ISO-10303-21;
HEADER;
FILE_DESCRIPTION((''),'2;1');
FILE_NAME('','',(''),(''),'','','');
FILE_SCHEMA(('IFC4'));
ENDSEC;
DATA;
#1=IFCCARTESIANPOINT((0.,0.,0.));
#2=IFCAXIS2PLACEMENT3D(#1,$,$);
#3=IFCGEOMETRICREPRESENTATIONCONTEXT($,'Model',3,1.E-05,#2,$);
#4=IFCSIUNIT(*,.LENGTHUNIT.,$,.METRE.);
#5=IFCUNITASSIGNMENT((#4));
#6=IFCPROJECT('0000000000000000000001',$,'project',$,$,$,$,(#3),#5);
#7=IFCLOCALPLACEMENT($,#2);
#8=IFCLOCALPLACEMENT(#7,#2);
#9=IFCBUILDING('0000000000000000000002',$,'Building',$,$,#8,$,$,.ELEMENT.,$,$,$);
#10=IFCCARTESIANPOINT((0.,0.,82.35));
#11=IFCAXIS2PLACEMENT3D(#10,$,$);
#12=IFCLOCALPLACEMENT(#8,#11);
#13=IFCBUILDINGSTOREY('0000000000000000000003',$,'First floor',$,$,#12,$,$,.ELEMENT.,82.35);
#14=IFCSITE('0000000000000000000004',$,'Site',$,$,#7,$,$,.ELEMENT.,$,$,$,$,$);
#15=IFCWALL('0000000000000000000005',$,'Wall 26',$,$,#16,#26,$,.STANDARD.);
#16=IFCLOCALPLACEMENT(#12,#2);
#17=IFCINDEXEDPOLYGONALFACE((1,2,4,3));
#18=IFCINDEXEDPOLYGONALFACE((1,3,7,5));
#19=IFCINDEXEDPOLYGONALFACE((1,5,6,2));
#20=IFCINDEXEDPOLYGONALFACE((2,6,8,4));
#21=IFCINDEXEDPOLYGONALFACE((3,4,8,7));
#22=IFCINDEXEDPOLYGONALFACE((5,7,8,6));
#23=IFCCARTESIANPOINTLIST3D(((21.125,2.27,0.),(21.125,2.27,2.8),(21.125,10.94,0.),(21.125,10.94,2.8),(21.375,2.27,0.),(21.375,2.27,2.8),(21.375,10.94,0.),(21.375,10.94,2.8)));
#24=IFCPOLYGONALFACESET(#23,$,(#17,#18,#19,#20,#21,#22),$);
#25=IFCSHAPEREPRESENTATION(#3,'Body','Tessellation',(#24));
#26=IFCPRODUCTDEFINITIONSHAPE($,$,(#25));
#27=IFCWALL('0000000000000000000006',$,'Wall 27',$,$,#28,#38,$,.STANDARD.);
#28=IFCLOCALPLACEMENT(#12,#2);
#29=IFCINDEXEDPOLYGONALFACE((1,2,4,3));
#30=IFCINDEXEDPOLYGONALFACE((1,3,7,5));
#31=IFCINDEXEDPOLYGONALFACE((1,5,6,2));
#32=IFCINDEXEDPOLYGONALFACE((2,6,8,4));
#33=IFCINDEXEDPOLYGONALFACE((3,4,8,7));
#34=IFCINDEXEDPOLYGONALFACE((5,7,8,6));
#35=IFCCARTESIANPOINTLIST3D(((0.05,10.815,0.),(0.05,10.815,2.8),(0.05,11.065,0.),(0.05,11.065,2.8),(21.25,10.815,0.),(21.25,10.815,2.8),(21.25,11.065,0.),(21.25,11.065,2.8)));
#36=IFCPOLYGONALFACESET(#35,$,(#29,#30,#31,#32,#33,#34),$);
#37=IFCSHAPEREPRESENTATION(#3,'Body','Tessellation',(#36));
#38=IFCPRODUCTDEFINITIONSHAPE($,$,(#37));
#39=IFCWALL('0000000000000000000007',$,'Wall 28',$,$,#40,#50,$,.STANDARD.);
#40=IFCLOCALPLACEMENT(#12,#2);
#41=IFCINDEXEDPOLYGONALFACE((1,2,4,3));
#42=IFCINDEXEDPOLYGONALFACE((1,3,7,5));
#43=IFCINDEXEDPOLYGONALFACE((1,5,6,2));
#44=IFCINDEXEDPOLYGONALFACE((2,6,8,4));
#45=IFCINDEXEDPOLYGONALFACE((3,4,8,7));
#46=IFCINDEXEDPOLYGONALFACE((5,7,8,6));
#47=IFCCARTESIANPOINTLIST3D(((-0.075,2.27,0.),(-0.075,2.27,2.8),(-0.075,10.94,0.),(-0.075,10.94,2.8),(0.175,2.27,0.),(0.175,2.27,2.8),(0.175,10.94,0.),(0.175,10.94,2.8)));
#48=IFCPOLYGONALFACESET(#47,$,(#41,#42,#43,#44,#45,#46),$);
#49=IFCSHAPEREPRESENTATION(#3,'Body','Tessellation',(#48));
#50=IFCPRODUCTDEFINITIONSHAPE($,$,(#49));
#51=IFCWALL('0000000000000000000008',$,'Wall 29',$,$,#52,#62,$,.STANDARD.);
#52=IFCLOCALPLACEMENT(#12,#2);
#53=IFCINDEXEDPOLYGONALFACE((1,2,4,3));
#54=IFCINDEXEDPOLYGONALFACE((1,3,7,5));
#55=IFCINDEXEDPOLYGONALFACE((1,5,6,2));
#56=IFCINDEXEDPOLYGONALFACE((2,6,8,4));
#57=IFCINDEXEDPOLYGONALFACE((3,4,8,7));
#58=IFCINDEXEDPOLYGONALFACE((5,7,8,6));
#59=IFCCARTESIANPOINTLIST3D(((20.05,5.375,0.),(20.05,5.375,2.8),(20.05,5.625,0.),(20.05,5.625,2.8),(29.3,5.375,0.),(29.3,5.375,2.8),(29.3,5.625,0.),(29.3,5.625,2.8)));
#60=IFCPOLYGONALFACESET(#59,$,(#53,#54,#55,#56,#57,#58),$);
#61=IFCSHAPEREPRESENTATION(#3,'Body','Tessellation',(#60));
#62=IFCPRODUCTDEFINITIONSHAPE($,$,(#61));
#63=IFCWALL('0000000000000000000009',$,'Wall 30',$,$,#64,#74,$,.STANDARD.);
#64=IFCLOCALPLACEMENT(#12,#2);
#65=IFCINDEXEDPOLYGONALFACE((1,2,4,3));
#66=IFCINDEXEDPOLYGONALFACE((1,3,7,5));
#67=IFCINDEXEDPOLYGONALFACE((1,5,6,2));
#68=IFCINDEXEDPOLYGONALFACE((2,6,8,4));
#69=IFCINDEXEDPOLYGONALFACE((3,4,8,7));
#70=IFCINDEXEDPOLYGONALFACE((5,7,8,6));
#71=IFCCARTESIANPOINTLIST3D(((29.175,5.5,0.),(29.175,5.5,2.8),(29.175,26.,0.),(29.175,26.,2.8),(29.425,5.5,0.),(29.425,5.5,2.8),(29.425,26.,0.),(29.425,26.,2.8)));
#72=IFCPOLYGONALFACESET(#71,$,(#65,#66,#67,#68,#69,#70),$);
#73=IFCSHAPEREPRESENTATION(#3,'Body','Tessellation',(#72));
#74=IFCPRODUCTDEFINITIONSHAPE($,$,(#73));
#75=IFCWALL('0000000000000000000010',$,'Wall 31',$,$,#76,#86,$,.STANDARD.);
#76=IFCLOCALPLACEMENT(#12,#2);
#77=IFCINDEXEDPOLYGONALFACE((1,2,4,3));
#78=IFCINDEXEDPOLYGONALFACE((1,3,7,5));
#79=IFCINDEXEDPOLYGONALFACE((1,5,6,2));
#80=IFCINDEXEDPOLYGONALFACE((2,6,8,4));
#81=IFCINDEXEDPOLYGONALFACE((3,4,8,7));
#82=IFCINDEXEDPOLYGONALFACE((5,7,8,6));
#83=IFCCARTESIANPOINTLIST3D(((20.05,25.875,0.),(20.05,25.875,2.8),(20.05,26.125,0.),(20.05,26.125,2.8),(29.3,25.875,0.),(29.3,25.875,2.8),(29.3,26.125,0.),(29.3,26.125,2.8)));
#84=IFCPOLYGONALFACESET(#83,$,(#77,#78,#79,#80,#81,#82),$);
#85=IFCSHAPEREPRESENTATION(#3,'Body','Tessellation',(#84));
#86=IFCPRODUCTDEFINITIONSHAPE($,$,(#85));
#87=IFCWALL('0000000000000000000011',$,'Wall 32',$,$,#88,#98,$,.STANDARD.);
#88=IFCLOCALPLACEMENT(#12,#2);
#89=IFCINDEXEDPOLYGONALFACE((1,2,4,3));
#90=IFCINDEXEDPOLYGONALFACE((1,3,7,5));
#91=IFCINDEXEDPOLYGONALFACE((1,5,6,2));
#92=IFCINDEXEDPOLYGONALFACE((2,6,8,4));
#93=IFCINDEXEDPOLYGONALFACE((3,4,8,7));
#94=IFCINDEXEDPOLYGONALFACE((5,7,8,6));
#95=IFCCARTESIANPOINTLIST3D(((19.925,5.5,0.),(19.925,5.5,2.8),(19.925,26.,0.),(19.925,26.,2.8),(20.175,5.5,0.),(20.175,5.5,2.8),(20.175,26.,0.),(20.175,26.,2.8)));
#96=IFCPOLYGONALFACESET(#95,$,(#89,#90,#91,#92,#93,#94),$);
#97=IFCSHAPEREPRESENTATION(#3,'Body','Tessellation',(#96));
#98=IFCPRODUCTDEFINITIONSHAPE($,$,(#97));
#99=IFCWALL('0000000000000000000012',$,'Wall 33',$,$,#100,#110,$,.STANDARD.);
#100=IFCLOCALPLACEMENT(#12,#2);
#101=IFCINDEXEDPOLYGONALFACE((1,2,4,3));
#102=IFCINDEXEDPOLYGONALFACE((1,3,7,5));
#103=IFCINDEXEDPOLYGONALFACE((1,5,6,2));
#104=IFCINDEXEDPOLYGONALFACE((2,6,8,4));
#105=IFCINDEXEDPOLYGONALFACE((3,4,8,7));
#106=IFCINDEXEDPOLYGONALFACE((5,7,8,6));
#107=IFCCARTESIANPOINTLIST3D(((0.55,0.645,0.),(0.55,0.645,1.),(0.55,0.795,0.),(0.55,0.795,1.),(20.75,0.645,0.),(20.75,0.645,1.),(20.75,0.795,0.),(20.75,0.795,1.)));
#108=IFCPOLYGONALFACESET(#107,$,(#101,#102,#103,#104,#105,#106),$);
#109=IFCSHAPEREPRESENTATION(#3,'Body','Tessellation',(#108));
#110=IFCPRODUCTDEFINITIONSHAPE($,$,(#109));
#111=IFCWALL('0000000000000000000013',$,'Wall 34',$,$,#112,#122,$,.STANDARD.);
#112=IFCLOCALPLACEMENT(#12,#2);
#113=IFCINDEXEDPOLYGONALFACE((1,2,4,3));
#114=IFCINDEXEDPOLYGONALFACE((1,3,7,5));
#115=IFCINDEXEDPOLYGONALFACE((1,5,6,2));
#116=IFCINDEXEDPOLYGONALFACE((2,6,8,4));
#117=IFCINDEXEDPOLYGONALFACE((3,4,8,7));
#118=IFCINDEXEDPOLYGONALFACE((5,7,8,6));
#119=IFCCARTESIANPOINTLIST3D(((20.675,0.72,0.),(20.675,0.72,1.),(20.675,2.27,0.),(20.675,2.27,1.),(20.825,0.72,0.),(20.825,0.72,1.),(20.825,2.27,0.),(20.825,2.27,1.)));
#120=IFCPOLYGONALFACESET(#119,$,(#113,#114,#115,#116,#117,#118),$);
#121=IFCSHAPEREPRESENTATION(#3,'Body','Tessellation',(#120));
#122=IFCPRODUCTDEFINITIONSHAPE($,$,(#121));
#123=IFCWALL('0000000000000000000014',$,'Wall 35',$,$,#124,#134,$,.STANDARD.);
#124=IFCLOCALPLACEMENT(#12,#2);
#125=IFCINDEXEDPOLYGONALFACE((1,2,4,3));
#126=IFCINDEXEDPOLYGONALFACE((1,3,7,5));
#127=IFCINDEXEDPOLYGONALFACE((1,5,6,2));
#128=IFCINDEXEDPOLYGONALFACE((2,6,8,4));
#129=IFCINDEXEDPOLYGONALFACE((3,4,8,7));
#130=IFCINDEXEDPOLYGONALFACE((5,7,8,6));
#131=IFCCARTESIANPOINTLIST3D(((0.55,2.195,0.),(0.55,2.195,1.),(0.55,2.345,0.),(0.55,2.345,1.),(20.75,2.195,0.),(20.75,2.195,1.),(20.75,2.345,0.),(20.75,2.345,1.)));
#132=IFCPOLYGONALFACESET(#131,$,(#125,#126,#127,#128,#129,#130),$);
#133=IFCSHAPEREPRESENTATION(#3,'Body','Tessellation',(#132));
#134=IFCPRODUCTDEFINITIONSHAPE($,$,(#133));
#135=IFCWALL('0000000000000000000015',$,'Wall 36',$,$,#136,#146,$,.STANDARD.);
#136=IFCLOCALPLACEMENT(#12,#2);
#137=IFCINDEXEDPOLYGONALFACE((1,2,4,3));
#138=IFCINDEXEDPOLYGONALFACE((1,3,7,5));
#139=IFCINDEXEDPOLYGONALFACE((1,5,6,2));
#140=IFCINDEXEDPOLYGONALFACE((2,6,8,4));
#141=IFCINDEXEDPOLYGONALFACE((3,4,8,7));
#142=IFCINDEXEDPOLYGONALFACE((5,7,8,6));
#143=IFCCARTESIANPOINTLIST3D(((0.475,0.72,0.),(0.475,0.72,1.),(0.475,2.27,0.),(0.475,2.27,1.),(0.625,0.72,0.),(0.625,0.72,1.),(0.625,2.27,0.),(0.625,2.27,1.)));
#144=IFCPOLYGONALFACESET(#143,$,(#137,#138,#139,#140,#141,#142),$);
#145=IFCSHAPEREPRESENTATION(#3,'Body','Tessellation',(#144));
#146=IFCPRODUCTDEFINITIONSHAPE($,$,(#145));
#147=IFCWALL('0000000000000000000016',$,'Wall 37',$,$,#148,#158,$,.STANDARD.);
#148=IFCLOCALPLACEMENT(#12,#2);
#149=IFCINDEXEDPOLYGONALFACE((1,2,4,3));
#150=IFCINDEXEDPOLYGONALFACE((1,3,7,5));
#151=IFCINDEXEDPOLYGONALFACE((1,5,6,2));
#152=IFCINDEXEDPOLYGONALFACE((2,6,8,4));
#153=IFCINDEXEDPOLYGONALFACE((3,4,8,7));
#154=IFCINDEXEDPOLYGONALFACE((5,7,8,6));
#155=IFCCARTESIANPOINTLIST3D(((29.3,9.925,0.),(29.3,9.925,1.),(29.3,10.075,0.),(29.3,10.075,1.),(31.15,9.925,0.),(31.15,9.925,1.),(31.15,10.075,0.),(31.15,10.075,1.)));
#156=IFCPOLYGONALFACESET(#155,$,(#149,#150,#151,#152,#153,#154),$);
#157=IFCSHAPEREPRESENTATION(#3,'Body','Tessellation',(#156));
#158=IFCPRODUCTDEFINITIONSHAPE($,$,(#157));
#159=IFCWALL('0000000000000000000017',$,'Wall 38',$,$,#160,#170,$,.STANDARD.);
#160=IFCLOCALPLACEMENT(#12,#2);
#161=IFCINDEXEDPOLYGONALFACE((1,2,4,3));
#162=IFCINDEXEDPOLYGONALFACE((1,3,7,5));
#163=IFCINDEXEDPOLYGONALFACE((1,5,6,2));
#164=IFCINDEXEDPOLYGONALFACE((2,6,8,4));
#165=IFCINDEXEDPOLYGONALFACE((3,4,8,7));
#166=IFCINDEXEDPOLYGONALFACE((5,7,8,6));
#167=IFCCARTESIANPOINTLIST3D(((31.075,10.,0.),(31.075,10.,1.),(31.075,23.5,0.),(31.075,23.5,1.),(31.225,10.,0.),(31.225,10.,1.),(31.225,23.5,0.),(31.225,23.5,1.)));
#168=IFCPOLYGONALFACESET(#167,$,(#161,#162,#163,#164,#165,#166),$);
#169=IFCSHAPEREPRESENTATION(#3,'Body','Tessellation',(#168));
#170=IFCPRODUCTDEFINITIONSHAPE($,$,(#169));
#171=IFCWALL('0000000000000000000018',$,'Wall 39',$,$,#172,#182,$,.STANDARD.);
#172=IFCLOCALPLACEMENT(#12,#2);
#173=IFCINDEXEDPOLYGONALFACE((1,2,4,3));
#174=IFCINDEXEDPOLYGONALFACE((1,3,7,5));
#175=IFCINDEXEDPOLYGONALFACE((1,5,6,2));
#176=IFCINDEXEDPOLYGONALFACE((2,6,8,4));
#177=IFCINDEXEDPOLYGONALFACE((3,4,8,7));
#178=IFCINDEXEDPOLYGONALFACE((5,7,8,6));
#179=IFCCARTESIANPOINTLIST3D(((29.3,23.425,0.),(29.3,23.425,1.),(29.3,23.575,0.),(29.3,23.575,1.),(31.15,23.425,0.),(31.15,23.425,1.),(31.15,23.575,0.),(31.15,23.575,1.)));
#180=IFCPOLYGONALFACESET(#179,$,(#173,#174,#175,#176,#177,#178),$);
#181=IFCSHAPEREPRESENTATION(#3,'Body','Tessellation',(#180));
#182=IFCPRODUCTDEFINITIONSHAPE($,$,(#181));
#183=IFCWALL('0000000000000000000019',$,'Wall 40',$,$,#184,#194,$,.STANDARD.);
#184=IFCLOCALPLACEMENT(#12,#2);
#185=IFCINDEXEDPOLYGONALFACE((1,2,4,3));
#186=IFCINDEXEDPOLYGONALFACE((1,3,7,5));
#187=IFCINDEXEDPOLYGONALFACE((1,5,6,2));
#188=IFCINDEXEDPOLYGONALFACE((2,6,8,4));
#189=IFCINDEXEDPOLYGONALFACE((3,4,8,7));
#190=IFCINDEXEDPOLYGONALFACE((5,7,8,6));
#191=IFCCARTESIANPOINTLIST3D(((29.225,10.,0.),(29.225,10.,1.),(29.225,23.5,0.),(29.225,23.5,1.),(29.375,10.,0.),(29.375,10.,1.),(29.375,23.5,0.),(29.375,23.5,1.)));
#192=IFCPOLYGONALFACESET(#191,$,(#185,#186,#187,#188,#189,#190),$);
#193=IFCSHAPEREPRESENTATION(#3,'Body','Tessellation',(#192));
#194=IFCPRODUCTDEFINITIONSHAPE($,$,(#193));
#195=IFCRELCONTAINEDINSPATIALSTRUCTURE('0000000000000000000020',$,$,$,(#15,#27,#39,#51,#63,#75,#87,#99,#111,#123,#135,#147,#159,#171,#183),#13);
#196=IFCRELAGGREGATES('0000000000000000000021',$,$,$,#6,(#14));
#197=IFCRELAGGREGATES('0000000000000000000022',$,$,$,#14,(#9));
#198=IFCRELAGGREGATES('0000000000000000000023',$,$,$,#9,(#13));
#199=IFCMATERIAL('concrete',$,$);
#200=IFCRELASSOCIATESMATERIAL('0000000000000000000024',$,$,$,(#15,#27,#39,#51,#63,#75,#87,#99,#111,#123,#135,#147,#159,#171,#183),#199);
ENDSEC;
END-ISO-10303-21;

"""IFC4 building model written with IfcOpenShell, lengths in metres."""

from ifc_helpers import new_model, si_unit, frame, frame_2d, origin, place, context, project, spatial, rectangle, extrude, material, element, save


model = new_model("IFC4")

# Units and contexts
model_context = context("Model", 3, precision=1e-05, world=origin())
ifc_project = project(units=[si_unit("LENGTHUNIT", "METRE")], contexts=[model_context])

# Site, building, storey
site_placement = place(None, origin())
site = spatial("IfcSite", under=ifc_project, at=site_placement, Name="Site", CompositionType="ELEMENT")
building_placement = place(site_placement, origin())
building = spatial("IfcBuilding", under=site, at=building_placement, Name="Building", CompositionType="ELEMENT")
storey_placement = place(building_placement, frame((0.0, 0.0, 82.35)))
storey = spatial("IfcBuildingStorey", under=building, at=storey_placement, Name="First floor", CompositionType="ELEMENT", Elevation=82.35)

# Shared definitions
ifc_material = material(Name="concrete")

# Walls
wall_1_placement = place(storey_placement, frame((21.25, 2.27, 0.0), z_axis=(0.0, 0.0, 1.0), x_axis=(0.0, 1.0, 0.0)))
element("IfcWall", 1, at=wall_1_placement, inside=storey, material=ifc_material, Name="Wall 26", PredefinedType="STANDARD", context=model_context, shape_type="SweptSolid", body=[
    extrude(rectangle(XDim=8.67, YDim=0.25, at=frame_2d((4.335, 0.0))), origin(), (0.0, 0.0, 1.0), 2.8),
])
wall_2_placement = place(storey_placement, frame((21.25, 10.94, 0.0), z_axis=(0.0, 0.0, 1.0), x_axis=(-1.0, 0.0, 0.0)))
element("IfcWall", 2, at=wall_2_placement, inside=storey, material=ifc_material, Name="Wall 27", PredefinedType="STANDARD", context=model_context, shape_type="SweptSolid", body=[
    extrude(rectangle(XDim=21.2, YDim=0.25, at=frame_2d((10.6, 0.0))), origin(), (0.0, 0.0, 1.0), 2.8),
])
wall_3_placement = place(storey_placement, frame((0.05, 10.94, 0.0), z_axis=(0.0, 0.0, 1.0), x_axis=(0.0, -1.0, 0.0)))
element("IfcWall", 3, at=wall_3_placement, inside=storey, material=ifc_material, Name="Wall 28", PredefinedType="STANDARD", context=model_context, shape_type="SweptSolid", body=[
    extrude(rectangle(XDim=8.67, YDim=0.25, at=frame_2d((4.335, 0.0))), origin(), (0.0, 0.0, 1.0), 2.8),
])
wall_4_placement = place(storey_placement, frame((20.05, 5.5, 0.0), z_axis=(0.0, 0.0, 1.0), x_axis=(1.0, 0.0, 0.0)))
element("IfcWall", 4, at=wall_4_placement, inside=storey, material=ifc_material, Name="Wall 29", PredefinedType="STANDARD", context=model_context, shape_type="SweptSolid", body=[
    extrude(rectangle(XDim=9.25, YDim=0.25, at=frame_2d((4.625, 0.0))), origin(), (0.0, 0.0, 1.0), 2.8),
])
wall_5_placement = place(storey_placement, frame((29.3, 5.5, 0.0), z_axis=(0.0, 0.0, 1.0), x_axis=(0.0, 1.0, 0.0)))
element("IfcWall", 5, at=wall_5_placement, inside=storey, material=ifc_material, Name="Wall 30", PredefinedType="STANDARD", context=model_context, shape_type="SweptSolid", body=[
    extrude(rectangle(XDim=20.5, YDim=0.25, at=frame_2d((10.25, 0.0))), origin(), (0.0, 0.0, 1.0), 2.8),
])
wall_6_placement = place(storey_placement, frame((29.3, 26.0, 0.0), z_axis=(0.0, 0.0, 1.0), x_axis=(-1.0, 0.0, 0.0)))
element("IfcWall", 6, at=wall_6_placement, inside=storey, material=ifc_material, Name="Wall 31", PredefinedType="STANDARD", context=model_context, shape_type="SweptSolid", body=[
    extrude(rectangle(XDim=9.25, YDim=0.25, at=frame_2d((4.625, 0.0))), origin(), (0.0, 0.0, 1.0), 2.8),
])
wall_7_placement = place(storey_placement, frame((20.05, 26.0, 0.0), z_axis=(0.0, 0.0, 1.0), x_axis=(0.0, -1.0, 0.0)))
element("IfcWall", 7, at=wall_7_placement, inside=storey, material=ifc_material, Name="Wall 32", PredefinedType="STANDARD", context=model_context, shape_type="SweptSolid", body=[
    extrude(rectangle(XDim=20.5, YDim=0.25, at=frame_2d((10.25, 0.0))), origin(), (0.0, 0.0, 1.0), 2.8),
])
wall_8_placement = place(storey_placement, frame((0.55, 0.72, 0.0), z_axis=(0.0, 0.0, 1.0), x_axis=(1.0, 0.0, 0.0)))
element("IfcWall", 8, at=wall_8_placement, inside=storey, material=ifc_material, Name="Wall 33", PredefinedType="STANDARD", context=model_context, shape_type="SweptSolid", body=[
    extrude(rectangle(XDim=20.2, YDim=0.15, at=frame_2d((10.1, 0.0))), origin(), (0.0, 0.0, 1.0), 1.0),
])
wall_9_placement = place(storey_placement, frame((20.75, 0.72, 0.0), z_axis=(0.0, 0.0, 1.0), x_axis=(0.0, 1.0, 0.0)))
element("IfcWall", 9, at=wall_9_placement, inside=storey, material=ifc_material, Name="Wall 34", PredefinedType="STANDARD", context=model_context, shape_type="SweptSolid", body=[
    extrude(rectangle(XDim=1.55, YDim=0.15, at=frame_2d((0.775, 0.0))), origin(), (0.0, 0.0, 1.0), 1.0),
])
wall_10_placement = place(storey_placement, frame((20.75, 2.27, 0.0), z_axis=(0.0, 0.0, 1.0), x_axis=(-1.0, 0.0, 0.0)))
element("IfcWall", 10, at=wall_10_placement, inside=storey, material=ifc_material, Name="Wall 35", PredefinedType="STANDARD", context=model_context, shape_type="SweptSolid", body=[
    extrude(rectangle(XDim=20.2, YDim=0.15, at=frame_2d((10.1, 0.0))), origin(), (0.0, 0.0, 1.0), 1.0),
])
wall_11_placement = place(storey_placement, frame((0.55, 2.27, 0.0), z_axis=(0.0, 0.0, 1.0), x_axis=(0.0, -1.0, 0.0)))
element("IfcWall", 11, at=wall_11_placement, inside=storey, material=ifc_material, Name="Wall 36", PredefinedType="STANDARD", context=model_context, shape_type="SweptSolid", body=[
    extrude(rectangle(XDim=1.55, YDim=0.15, at=frame_2d((0.775, 0.0))), origin(), (0.0, 0.0, 1.0), 1.0),
])
wall_12_placement = place(storey_placement, frame((29.3, 10.0, 0.0), z_axis=(0.0, 0.0, 1.0), x_axis=(1.0, 0.0, 0.0)))
element("IfcWall", 12, at=wall_12_placement, inside=storey, material=ifc_material, Name="Wall 37", PredefinedType="STANDARD", context=model_context, shape_type="SweptSolid", body=[
    extrude(rectangle(XDim=1.85, YDim=0.15, at=frame_2d((0.925, 0.0))), origin(), (0.0, 0.0, 1.0), 1.0),
])
wall_13_placement = place(storey_placement, frame((31.15, 10.0, 0.0), z_axis=(0.0, 0.0, 1.0), x_axis=(0.0, 1.0, 0.0)))
element("IfcWall", 13, at=wall_13_placement, inside=storey, material=ifc_material, Name="Wall 38", PredefinedType="STANDARD", context=model_context, shape_type="SweptSolid", body=[
    extrude(rectangle(XDim=13.5, YDim=0.15, at=frame_2d((6.75, 0.0))), origin(), (0.0, 0.0, 1.0), 1.0),
])
wall_14_placement = place(storey_placement, frame((31.15, 23.5, 0.0), z_axis=(0.0, 0.0, 1.0), x_axis=(-1.0, 0.0, 0.0)))
element("IfcWall", 14, at=wall_14_placement, inside=storey, material=ifc_material, Name="Wall 39", PredefinedType="STANDARD", context=model_context, shape_type="SweptSolid", body=[
    extrude(rectangle(XDim=1.85, YDim=0.15, at=frame_2d((0.925, 0.0))), origin(), (0.0, 0.0, 1.0), 1.0),
])
wall_15_placement = place(storey_placement, frame((29.3, 23.5, 0.0), z_axis=(0.0, 0.0, 1.0), x_axis=(0.0, -1.0, 0.0)))
element("IfcWall", 15, at=wall_15_placement, inside=storey, material=ifc_material, Name="Wall 40", PredefinedType="STANDARD", context=model_context, shape_type="SweptSolid", body=[
    extrude(rectangle(XDim=13.5, YDim=0.15, at=frame_2d((6.75, 0.0))), origin(), (0.0, 0.0, 1.0), 1.0),
])

save(model, "model.ifc")
